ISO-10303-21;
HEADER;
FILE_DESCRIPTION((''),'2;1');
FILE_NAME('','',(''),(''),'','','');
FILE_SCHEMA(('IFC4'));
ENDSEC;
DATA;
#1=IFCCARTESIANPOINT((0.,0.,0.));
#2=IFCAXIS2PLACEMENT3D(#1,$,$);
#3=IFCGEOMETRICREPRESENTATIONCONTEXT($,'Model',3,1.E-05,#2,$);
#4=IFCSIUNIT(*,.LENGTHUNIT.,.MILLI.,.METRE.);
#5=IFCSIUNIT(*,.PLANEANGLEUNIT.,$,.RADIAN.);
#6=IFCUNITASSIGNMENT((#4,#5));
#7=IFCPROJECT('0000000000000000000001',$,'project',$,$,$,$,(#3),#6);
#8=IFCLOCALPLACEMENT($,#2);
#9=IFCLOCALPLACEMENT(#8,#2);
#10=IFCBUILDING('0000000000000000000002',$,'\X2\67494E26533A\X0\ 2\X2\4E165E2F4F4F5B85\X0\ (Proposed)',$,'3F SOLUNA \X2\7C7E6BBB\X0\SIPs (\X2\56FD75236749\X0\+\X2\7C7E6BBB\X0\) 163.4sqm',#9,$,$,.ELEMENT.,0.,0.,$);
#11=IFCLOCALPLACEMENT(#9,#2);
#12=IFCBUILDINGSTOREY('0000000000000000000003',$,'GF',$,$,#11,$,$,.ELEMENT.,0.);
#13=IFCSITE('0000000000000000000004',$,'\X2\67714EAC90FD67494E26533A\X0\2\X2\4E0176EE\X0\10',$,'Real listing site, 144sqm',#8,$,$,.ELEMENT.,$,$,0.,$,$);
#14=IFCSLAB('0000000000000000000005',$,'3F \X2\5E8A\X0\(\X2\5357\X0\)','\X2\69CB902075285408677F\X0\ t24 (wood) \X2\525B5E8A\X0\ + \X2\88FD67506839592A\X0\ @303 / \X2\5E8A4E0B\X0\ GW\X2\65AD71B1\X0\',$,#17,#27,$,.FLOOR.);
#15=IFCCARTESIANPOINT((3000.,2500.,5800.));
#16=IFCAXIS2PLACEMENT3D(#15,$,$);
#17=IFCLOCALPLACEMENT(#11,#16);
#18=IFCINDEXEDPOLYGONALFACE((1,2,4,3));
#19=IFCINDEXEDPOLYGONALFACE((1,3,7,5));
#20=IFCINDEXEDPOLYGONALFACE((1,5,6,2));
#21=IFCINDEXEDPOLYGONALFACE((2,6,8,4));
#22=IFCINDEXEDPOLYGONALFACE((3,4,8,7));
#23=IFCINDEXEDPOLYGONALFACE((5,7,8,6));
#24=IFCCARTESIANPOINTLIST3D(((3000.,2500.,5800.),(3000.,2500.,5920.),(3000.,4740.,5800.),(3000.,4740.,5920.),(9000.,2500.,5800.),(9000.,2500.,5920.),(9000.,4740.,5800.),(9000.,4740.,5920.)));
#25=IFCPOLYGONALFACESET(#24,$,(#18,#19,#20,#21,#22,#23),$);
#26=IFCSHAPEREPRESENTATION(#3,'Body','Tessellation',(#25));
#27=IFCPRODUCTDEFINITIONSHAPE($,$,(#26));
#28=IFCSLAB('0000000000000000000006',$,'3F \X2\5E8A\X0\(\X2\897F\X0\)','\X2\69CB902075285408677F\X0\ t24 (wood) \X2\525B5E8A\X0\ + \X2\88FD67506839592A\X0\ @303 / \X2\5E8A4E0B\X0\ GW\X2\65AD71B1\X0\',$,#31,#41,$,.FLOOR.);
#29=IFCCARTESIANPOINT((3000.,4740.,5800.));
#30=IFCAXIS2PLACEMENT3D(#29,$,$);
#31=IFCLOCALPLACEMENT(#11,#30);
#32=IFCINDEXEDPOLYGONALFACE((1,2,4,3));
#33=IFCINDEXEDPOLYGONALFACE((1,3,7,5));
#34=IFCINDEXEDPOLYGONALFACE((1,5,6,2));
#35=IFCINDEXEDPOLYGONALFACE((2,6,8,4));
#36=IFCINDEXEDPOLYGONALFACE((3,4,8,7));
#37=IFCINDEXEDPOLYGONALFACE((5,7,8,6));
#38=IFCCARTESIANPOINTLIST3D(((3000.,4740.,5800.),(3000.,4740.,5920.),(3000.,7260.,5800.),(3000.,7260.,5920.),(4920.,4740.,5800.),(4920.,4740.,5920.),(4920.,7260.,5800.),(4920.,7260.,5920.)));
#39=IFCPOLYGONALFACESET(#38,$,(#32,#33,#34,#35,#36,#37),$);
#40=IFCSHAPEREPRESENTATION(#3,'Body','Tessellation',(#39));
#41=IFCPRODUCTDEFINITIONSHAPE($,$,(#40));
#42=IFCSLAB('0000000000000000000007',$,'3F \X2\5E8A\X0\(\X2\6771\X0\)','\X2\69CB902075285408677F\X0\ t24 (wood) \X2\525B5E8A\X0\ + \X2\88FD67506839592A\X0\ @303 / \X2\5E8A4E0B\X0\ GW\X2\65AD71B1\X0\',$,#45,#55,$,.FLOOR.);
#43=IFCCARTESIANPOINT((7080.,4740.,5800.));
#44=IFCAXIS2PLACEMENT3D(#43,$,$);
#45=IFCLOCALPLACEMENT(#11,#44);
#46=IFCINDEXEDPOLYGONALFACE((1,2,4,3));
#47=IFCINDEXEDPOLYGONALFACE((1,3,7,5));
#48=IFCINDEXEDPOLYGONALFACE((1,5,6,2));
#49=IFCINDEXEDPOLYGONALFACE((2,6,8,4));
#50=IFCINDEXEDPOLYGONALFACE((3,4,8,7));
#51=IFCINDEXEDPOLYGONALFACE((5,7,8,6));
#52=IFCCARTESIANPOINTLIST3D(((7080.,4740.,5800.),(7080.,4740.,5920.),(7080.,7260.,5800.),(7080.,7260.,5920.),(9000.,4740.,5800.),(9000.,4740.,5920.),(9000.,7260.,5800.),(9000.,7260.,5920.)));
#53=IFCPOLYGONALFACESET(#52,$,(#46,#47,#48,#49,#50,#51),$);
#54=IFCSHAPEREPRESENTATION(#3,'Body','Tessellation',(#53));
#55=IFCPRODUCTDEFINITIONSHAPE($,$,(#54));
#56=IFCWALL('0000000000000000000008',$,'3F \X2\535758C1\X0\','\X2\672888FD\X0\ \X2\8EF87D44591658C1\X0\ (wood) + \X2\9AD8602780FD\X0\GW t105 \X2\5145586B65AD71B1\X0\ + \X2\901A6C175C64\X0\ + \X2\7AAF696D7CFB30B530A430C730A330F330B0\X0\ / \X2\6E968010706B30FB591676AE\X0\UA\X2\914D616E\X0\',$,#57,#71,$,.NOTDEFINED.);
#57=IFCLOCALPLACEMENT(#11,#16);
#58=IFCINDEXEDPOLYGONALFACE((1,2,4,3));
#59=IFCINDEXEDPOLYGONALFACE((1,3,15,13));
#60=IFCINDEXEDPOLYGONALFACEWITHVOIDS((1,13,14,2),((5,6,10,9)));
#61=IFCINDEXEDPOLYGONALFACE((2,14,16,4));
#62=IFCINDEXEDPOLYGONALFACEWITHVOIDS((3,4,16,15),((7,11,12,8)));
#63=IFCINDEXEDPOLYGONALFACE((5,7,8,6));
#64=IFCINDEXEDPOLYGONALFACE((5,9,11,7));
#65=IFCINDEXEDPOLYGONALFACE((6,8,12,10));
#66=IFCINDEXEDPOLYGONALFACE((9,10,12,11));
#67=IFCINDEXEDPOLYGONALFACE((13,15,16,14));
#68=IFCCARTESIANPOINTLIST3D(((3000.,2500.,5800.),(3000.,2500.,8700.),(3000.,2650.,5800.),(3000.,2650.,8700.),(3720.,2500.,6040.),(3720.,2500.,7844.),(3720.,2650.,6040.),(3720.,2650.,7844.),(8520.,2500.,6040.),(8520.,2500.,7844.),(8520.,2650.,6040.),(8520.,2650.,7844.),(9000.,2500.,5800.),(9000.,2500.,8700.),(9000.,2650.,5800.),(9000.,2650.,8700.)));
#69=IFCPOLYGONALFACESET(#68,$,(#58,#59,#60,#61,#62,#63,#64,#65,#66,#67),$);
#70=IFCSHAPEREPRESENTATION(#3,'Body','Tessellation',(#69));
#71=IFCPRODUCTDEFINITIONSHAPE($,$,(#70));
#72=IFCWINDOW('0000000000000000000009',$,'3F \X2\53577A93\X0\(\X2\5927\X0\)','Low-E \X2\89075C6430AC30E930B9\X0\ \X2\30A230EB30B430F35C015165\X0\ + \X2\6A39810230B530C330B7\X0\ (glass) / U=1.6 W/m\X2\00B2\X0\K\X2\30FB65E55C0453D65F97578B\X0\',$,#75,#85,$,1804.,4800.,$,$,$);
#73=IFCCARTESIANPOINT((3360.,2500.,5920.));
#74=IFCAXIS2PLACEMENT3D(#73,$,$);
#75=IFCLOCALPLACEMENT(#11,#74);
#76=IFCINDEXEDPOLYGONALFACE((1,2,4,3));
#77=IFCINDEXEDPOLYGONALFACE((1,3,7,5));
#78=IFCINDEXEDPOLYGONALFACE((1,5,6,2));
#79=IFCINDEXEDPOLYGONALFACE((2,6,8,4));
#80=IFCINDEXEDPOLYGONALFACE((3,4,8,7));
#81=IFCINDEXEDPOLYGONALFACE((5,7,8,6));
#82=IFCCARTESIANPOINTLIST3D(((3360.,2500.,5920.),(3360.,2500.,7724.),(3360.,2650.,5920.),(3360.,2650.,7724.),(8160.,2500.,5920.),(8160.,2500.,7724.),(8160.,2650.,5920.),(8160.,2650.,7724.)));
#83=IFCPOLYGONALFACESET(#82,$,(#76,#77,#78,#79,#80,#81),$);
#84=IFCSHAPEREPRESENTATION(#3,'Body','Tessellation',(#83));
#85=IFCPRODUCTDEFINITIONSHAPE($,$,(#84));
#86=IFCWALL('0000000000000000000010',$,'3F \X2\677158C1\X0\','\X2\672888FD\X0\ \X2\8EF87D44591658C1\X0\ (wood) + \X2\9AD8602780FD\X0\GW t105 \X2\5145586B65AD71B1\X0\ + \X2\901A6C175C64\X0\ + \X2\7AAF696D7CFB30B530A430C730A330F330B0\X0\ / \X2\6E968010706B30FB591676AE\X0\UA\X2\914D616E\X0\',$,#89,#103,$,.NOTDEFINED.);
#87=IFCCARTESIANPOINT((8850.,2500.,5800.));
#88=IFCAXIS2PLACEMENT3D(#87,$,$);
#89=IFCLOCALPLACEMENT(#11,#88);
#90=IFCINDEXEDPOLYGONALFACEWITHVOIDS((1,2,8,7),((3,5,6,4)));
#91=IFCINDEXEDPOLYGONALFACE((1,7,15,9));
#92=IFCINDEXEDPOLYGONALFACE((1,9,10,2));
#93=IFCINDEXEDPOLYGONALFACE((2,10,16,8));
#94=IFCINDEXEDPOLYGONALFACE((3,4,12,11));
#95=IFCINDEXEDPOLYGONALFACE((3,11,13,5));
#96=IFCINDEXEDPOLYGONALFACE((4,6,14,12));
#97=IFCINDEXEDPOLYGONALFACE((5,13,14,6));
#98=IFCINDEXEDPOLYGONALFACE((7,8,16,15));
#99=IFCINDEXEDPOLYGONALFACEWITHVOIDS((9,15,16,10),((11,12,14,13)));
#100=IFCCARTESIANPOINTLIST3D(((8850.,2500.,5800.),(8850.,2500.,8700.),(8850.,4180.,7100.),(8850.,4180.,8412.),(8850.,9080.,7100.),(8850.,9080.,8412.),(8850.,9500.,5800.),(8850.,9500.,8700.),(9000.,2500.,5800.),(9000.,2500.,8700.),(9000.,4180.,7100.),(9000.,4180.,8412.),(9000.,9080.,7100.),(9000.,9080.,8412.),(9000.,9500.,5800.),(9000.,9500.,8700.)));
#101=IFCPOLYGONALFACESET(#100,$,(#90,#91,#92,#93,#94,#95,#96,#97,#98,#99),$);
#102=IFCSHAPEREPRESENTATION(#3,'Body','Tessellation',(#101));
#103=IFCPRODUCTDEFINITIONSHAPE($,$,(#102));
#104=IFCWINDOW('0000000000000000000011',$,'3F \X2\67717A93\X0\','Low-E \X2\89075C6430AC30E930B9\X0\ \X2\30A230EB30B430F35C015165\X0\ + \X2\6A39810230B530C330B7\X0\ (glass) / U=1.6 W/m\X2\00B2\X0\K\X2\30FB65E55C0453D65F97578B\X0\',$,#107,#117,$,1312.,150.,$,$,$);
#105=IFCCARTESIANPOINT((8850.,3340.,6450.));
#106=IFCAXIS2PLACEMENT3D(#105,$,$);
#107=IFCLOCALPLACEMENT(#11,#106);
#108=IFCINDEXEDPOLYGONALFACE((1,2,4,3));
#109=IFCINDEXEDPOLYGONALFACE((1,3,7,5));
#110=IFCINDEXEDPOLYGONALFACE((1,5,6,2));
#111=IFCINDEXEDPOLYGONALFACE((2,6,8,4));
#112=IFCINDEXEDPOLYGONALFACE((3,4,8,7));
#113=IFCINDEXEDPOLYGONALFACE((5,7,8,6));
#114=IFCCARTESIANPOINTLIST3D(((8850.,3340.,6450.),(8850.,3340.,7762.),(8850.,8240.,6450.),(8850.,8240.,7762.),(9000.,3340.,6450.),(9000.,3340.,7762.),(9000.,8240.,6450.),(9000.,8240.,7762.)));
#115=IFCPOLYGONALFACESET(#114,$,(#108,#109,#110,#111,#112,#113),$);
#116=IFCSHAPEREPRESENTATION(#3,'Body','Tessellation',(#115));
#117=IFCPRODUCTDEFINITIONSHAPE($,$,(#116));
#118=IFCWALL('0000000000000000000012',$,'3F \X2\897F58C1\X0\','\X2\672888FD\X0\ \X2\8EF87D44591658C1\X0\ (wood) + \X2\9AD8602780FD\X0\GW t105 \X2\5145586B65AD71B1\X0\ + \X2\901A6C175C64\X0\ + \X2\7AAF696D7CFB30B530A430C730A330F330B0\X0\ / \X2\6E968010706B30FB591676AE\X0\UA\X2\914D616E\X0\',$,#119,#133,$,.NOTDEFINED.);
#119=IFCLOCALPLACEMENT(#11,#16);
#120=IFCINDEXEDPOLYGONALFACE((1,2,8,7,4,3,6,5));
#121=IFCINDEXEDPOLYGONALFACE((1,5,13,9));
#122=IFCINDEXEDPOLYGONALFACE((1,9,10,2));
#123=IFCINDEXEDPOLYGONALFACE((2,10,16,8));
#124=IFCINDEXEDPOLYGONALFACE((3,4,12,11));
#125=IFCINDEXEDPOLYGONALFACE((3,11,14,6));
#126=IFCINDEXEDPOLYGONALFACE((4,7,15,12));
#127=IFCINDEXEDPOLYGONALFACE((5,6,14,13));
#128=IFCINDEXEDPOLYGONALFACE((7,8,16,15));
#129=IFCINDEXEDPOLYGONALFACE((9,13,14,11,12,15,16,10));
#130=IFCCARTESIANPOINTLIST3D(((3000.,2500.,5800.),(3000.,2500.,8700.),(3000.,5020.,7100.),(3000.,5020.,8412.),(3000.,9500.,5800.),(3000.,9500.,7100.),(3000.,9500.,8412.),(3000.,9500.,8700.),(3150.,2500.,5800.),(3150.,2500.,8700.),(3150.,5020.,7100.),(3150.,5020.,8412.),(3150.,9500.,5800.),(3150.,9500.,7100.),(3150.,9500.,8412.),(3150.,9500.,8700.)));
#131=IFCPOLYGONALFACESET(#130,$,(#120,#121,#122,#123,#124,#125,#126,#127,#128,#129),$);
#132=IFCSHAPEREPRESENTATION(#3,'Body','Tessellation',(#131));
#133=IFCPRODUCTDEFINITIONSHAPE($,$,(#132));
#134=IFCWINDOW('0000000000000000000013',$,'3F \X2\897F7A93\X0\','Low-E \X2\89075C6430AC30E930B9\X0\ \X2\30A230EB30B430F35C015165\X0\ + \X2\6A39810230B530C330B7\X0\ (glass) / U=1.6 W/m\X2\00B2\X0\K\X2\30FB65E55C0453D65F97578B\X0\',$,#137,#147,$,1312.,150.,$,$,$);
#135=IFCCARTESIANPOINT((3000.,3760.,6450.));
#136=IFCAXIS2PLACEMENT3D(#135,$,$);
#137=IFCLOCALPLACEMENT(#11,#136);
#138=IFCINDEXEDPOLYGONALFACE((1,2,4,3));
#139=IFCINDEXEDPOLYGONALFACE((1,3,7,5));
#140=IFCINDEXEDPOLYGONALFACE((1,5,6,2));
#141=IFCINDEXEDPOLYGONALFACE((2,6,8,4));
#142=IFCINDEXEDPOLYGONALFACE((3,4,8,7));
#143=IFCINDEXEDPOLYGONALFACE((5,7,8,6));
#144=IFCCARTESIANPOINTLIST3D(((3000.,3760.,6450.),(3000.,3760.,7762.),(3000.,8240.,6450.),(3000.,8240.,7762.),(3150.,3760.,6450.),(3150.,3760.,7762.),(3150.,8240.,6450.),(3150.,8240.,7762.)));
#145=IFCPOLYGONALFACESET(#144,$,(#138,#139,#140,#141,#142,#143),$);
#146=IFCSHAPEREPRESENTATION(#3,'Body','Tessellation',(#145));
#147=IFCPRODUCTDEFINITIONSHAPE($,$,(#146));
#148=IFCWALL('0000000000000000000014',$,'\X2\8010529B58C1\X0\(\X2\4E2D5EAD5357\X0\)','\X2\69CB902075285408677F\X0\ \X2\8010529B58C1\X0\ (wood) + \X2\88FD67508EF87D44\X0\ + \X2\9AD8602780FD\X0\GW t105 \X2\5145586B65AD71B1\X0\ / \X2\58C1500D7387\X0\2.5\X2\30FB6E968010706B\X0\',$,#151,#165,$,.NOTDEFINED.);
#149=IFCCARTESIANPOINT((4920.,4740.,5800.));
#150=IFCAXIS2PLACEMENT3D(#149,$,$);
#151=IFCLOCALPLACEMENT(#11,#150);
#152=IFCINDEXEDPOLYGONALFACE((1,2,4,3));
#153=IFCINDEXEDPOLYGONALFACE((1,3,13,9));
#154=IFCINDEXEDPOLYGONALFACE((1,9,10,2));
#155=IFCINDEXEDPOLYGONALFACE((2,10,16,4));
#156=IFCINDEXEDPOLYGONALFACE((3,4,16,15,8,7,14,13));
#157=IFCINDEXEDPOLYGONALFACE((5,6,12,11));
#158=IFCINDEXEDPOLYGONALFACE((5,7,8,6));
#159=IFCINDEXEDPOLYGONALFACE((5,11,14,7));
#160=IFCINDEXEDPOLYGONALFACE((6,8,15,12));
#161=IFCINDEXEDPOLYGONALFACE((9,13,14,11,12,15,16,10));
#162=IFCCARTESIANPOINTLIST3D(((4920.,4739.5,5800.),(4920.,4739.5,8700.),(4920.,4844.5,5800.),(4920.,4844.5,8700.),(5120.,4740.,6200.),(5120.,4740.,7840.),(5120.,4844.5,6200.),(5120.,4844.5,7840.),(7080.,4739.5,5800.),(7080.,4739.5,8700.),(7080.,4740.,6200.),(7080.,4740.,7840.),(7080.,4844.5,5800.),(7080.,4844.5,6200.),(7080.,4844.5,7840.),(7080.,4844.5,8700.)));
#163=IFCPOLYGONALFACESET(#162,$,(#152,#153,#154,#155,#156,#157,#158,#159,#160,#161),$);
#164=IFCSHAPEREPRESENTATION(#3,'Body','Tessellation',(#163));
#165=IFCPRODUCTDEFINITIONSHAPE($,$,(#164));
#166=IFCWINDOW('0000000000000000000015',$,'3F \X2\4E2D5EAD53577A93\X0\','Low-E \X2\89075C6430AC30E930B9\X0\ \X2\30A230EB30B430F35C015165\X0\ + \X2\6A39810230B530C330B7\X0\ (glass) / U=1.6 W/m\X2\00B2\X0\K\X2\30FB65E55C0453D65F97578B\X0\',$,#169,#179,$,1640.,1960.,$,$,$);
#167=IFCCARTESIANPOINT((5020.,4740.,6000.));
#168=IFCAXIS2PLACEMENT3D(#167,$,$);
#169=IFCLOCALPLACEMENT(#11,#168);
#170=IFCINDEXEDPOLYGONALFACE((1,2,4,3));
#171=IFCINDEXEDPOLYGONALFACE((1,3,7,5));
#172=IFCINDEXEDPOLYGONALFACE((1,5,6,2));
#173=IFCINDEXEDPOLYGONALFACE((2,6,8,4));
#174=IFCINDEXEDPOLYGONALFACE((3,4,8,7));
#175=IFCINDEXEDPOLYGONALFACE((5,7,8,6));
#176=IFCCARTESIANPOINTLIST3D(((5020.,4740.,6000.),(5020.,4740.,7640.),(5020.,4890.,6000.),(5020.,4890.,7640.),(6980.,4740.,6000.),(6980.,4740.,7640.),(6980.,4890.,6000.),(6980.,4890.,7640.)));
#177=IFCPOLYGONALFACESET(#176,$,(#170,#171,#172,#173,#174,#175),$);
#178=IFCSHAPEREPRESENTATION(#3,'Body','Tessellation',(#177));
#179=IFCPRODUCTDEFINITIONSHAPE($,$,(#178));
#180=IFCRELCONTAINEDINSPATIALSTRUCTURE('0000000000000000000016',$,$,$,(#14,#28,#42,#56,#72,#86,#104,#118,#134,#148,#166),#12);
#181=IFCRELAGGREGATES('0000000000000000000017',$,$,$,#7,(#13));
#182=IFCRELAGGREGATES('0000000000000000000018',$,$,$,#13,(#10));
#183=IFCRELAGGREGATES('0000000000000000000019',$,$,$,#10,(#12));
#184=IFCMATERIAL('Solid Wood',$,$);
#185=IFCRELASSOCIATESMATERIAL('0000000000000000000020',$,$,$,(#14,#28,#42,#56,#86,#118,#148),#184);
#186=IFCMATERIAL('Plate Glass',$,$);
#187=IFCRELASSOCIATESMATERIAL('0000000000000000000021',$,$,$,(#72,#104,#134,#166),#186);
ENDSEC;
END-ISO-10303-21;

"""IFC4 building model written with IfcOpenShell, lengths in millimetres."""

from ifc_helpers import new_model, si_unit, frame, frame_2d, origin, place, context, project, spatial, rectangle, extrude, material, element, fill, save


model = new_model("IFC4")

# Units and contexts
model_context = context("Model", 3, precision=1e-05, world=origin())
ifc_project = project(units=[si_unit("LENGTHUNIT", "METRE", prefix="MILLI"), si_unit("PLANEANGLEUNIT", "RADIAN")], contexts=[model_context])

# Site, building, storey
site_placement = place(None, origin())
site = spatial("IfcSite", under=ifc_project, at=site_placement, Name="東京都杉並区2丁目10", ObjectType="Real listing site, 144sqm", CompositionType="ELEMENT", RefElevation=0.0)
building_placement = place(site_placement, origin())
building = spatial("IfcBuilding", under=site, at=building_placement, Name="杉並区 2世帯住宅 (Proposed)", ObjectType="3F SOLUNA 籾殻SIPs (国産杉+籾殻) 163.4sqm", CompositionType="ELEMENT", ElevationOfRefHeight=0.0, ElevationOfTerrain=0.0)
storey_placement = place(building_placement, origin())
storey = spatial("IfcBuildingStorey", under=building, at=storey_placement, Name="GF", CompositionType="ELEMENT", Elevation=0.0)

# Slabs
ifc_material_1 = material(Name="Solid Wood")
slab_1_placement = place(storey_placement, frame((3000.0, 2500.0, 5800.0)))
element("IfcSlab", 1, at=slab_1_placement, inside=storey, material=ifc_material_1, Name="3F 床(南)", Description="構造用合板 t24 (wood) 剛床 + 製材根太 @303 / 床下 GW断熱", PredefinedType="FLOOR", context=model_context, shape_type="SweptSolid", body=[
    extrude(rectangle(XDim=6000.0, YDim=2240.0, at=frame_2d((3000.0, 1120.0))), frame((3000.0, 2500.0, 5800.0)), (0.0, 0.0, 1.0), 120.0),
])
slab_2_placement = place(storey_placement, frame((3000.0, 4740.0, 5800.0)))
element("IfcSlab", 2, at=slab_2_placement, inside=storey, material=ifc_material_1, Name="3F 床(西)", Description="構造用合板 t24 (wood) 剛床 + 製材根太 @303 / 床下 GW断熱", PredefinedType="FLOOR", context=model_context, shape_type="SweptSolid", body=[
    extrude(rectangle(XDim=1920.0, YDim=2520.0, at=frame_2d((960.0, 1260.0))), frame((3000.0, 4740.0, 5800.0)), (0.0, 0.0, 1.0), 120.0),
])
slab_3_placement = place(storey_placement, frame((7080.0, 4740.0, 5800.0)))
element("IfcSlab", 3, at=slab_3_placement, inside=storey, material=ifc_material_1, Name="3F 床(東)", Description="構造用合板 t24 (wood) 剛床 + 製材根太 @303 / 床下 GW断熱", PredefinedType="FLOOR", context=model_context, shape_type="SweptSolid", body=[
    extrude(rectangle(XDim=1920.0, YDim=2520.0, at=frame_2d((960.0, 1260.0))), frame((7080.0, 4740.0, 5800.0)), (0.0, 0.0, 1.0), 120.0),
])

# Walls, openings, windows
wall_1_placement = place(storey_placement, frame((3000.0, 2500.0, 5800.0)))
wall_1 = element("IfcWall", 4, at=wall_1_placement, inside=storey, material=ifc_material_1, Name="3F 南壁", Description="木製 軸組外壁 (wood) + 高性能GW t105 充填断熱 + 通気層 + 窯業系サイディング / 準耐火・外皮UA配慮", PredefinedType="NOTDEFINED", context=model_context, shape_type="SweptSolid", body=[
    extrude(rectangle(XDim=6000.0, YDim=150.0, at=frame_2d((3000.0, 75.0))), frame((3000.0, 2500.0, 5800.0)), (0.0, 0.0, 1.0), 2900.0),
])
opening_1_placement = place(storey_placement, frame((3360.0, 2500.0, 5920.0)))
opening_1 = element("IfcOpeningElement", 5, at=opening_1_placement, cuts=wall_1, PredefinedType="NOTDEFINED", context=model_context, shape_type="SweptSolid", body=[
    extrude(rectangle(XDim=4800.0, YDim=150.0, at=frame_2d((2400.0, 75.0))), frame((3360.0, 2500.0, 5920.0)), (0.0, 0.0, 1.0), 1804.0),
])
ifc_material_2 = material(Name="Plate Glass")
window_1_placement = place(storey_placement, frame((3360.0, 2500.0, 5920.0)))
window_1 = element("IfcWindow", 6, at=window_1_placement, inside=storey, material=ifc_material_2, Name="3F 南窓(大)", Description="Low-E 複層ガラス アルゴン封入 + 樹脂サッシ (glass) / U=1.6 W/m²K・日射取得型", OverallHeight=1804.0, OverallWidth=4800.0, context=model_context, shape_type="SweptSolid", body=[
    extrude(rectangle(XDim=4800.0, YDim=150.0, at=frame_2d((2400.0, 75.0))), frame((3360.0, 2500.0, 5920.0)), (0.0, 0.0, 1.0), 1804.0),
])
fill(opening_1, window_1)
wall_2_placement = place(storey_placement, frame((8850.0, 2500.0, 5800.0)))
wall_2 = element("IfcWall", 7, at=wall_2_placement, inside=storey, material=ifc_material_1, Name="3F 東壁", Description="木製 軸組外壁 (wood) + 高性能GW t105 充填断熱 + 通気層 + 窯業系サイディング / 準耐火・外皮UA配慮", PredefinedType="NOTDEFINED", context=model_context, shape_type="SweptSolid", body=[
    extrude(rectangle(XDim=150.0, YDim=7000.0, at=frame_2d((75.0, 3500.0))), frame((8850.0, 2500.0, 5800.0)), (0.0, 0.0, 1.0), 2900.0),
])
opening_2_placement = place(storey_placement, frame((8850.0, 3340.0, 6450.0)))
opening_2 = element("IfcOpeningElement", 8, at=opening_2_placement, cuts=wall_2, PredefinedType="NOTDEFINED", context=model_context, shape_type="SweptSolid", body=[
    extrude(rectangle(XDim=150.0, YDim=4900.0, at=frame_2d((75.0, 2450.0))), frame((8850.0, 3340.0, 6450.0)), (0.0, 0.0, 1.0), 1312.0),
])
window_2_placement = place(storey_placement, frame((8850.0, 3340.0, 6450.0)))
window_2 = element("IfcWindow", 9, at=window_2_placement, inside=storey, material=ifc_material_2, Name="3F 東窓", Description="Low-E 複層ガラス アルゴン封入 + 樹脂サッシ (glass) / U=1.6 W/m²K・日射取得型", OverallHeight=1312.0, OverallWidth=150.0, context=model_context, shape_type="SweptSolid", body=[
    extrude(rectangle(XDim=150.0, YDim=4900.0, at=frame_2d((75.0, 2450.0))), frame((8850.0, 3340.0, 6450.0)), (0.0, 0.0, 1.0), 1312.0),
])
fill(opening_2, window_2)
wall_3_placement = place(storey_placement, frame((3000.0, 2500.0, 5800.0)))
wall_3 = element("IfcWall", 10, at=wall_3_placement, inside=storey, material=ifc_material_1, Name="3F 西壁", Description="木製 軸組外壁 (wood) + 高性能GW t105 充填断熱 + 通気層 + 窯業系サイディング / 準耐火・外皮UA配慮", PredefinedType="NOTDEFINED", context=model_context, shape_type="SweptSolid", body=[
    extrude(rectangle(XDim=150.0, YDim=7000.0, at=frame_2d((75.0, 3500.0))), frame((3000.0, 2500.0, 5800.0)), (0.0, 0.0, 1.0), 2900.0),
])
opening_3_placement = place(storey_placement, frame((3000.0, 3760.0, 6450.0)))
opening_3 = element("IfcOpeningElement", 11, at=opening_3_placement, cuts=wall_3, PredefinedType="NOTDEFINED", context=model_context, shape_type="SweptSolid", body=[
    extrude(rectangle(XDim=150.0, YDim=4480.0, at=frame_2d((75.0, 2240.0))), frame((3000.0, 3760.0, 6450.0)), (0.0, 0.0, 1.0), 1312.0),
])
window_3_placement = place(storey_placement, frame((3000.0, 3760.0, 6450.0)))
window_3 = element("IfcWindow", 12, at=window_3_placement, inside=storey, material=ifc_material_2, Name="3F 西窓", Description="Low-E 複層ガラス アルゴン封入 + 樹脂サッシ (glass) / U=1.6 W/m²K・日射取得型", OverallHeight=1312.0, OverallWidth=150.0, context=model_context, shape_type="SweptSolid", body=[
    extrude(rectangle(XDim=150.0, YDim=4480.0, at=frame_2d((75.0, 2240.0))), frame((3000.0, 3760.0, 6450.0)), (0.0, 0.0, 1.0), 1312.0),
])
fill(opening_3, window_3)
wall_4_placement = place(storey_placement, frame((4920.0, 4740.0, 5800.0)))
wall_4 = element("IfcWall", 13, at=wall_4_placement, inside=storey, material=ifc_material_1, Name="耐力壁(中庭南)", Description="構造用合板 耐力壁 (wood) + 製材軸組 + 高性能GW t105 充填断熱 / 壁倍率2.5・準耐火", PredefinedType="NOTDEFINED", context=model_context, shape_type="SweptSolid", body=[
    extrude(rectangle(XDim=2160.0, YDim=105.0, at=frame_2d((1080.0, 52.0))), frame((4920.0, 4740.0, 5800.0)), (0.0, 0.0, 1.0), 2900.0),
])
opening_4_placement = place(storey_placement, frame((5020.0, 4740.0, 6000.0)))
opening_4 = element("IfcOpeningElement", 14, at=opening_4_placement, cuts=wall_4, PredefinedType="NOTDEFINED", context=model_context, shape_type="SweptSolid", body=[
    extrude(rectangle(XDim=1960.0, YDim=150.0, at=frame_2d((980.0, 75.0))), frame((5020.0, 4740.0, 6000.0)), (0.0, 0.0, 1.0), 1640.0),
])
window_4_placement = place(storey_placement, frame((5020.0, 4740.0, 6000.0)))
window_4 = element("IfcWindow", 15, at=window_4_placement, inside=storey, material=ifc_material_2, Name="3F 中庭南窓", Description="Low-E 複層ガラス アルゴン封入 + 樹脂サッシ (glass) / U=1.6 W/m²K・日射取得型", OverallHeight=1640.0, OverallWidth=1960.0, context=model_context, shape_type="SweptSolid", body=[
    extrude(rectangle(XDim=1960.0, YDim=150.0, at=frame_2d((980.0, 75.0))), frame((5020.0, 4740.0, 6000.0)), (0.0, 0.0, 1.0), 1640.0),
])
fill(opening_4, window_4)

save(model, "model.ifc")
